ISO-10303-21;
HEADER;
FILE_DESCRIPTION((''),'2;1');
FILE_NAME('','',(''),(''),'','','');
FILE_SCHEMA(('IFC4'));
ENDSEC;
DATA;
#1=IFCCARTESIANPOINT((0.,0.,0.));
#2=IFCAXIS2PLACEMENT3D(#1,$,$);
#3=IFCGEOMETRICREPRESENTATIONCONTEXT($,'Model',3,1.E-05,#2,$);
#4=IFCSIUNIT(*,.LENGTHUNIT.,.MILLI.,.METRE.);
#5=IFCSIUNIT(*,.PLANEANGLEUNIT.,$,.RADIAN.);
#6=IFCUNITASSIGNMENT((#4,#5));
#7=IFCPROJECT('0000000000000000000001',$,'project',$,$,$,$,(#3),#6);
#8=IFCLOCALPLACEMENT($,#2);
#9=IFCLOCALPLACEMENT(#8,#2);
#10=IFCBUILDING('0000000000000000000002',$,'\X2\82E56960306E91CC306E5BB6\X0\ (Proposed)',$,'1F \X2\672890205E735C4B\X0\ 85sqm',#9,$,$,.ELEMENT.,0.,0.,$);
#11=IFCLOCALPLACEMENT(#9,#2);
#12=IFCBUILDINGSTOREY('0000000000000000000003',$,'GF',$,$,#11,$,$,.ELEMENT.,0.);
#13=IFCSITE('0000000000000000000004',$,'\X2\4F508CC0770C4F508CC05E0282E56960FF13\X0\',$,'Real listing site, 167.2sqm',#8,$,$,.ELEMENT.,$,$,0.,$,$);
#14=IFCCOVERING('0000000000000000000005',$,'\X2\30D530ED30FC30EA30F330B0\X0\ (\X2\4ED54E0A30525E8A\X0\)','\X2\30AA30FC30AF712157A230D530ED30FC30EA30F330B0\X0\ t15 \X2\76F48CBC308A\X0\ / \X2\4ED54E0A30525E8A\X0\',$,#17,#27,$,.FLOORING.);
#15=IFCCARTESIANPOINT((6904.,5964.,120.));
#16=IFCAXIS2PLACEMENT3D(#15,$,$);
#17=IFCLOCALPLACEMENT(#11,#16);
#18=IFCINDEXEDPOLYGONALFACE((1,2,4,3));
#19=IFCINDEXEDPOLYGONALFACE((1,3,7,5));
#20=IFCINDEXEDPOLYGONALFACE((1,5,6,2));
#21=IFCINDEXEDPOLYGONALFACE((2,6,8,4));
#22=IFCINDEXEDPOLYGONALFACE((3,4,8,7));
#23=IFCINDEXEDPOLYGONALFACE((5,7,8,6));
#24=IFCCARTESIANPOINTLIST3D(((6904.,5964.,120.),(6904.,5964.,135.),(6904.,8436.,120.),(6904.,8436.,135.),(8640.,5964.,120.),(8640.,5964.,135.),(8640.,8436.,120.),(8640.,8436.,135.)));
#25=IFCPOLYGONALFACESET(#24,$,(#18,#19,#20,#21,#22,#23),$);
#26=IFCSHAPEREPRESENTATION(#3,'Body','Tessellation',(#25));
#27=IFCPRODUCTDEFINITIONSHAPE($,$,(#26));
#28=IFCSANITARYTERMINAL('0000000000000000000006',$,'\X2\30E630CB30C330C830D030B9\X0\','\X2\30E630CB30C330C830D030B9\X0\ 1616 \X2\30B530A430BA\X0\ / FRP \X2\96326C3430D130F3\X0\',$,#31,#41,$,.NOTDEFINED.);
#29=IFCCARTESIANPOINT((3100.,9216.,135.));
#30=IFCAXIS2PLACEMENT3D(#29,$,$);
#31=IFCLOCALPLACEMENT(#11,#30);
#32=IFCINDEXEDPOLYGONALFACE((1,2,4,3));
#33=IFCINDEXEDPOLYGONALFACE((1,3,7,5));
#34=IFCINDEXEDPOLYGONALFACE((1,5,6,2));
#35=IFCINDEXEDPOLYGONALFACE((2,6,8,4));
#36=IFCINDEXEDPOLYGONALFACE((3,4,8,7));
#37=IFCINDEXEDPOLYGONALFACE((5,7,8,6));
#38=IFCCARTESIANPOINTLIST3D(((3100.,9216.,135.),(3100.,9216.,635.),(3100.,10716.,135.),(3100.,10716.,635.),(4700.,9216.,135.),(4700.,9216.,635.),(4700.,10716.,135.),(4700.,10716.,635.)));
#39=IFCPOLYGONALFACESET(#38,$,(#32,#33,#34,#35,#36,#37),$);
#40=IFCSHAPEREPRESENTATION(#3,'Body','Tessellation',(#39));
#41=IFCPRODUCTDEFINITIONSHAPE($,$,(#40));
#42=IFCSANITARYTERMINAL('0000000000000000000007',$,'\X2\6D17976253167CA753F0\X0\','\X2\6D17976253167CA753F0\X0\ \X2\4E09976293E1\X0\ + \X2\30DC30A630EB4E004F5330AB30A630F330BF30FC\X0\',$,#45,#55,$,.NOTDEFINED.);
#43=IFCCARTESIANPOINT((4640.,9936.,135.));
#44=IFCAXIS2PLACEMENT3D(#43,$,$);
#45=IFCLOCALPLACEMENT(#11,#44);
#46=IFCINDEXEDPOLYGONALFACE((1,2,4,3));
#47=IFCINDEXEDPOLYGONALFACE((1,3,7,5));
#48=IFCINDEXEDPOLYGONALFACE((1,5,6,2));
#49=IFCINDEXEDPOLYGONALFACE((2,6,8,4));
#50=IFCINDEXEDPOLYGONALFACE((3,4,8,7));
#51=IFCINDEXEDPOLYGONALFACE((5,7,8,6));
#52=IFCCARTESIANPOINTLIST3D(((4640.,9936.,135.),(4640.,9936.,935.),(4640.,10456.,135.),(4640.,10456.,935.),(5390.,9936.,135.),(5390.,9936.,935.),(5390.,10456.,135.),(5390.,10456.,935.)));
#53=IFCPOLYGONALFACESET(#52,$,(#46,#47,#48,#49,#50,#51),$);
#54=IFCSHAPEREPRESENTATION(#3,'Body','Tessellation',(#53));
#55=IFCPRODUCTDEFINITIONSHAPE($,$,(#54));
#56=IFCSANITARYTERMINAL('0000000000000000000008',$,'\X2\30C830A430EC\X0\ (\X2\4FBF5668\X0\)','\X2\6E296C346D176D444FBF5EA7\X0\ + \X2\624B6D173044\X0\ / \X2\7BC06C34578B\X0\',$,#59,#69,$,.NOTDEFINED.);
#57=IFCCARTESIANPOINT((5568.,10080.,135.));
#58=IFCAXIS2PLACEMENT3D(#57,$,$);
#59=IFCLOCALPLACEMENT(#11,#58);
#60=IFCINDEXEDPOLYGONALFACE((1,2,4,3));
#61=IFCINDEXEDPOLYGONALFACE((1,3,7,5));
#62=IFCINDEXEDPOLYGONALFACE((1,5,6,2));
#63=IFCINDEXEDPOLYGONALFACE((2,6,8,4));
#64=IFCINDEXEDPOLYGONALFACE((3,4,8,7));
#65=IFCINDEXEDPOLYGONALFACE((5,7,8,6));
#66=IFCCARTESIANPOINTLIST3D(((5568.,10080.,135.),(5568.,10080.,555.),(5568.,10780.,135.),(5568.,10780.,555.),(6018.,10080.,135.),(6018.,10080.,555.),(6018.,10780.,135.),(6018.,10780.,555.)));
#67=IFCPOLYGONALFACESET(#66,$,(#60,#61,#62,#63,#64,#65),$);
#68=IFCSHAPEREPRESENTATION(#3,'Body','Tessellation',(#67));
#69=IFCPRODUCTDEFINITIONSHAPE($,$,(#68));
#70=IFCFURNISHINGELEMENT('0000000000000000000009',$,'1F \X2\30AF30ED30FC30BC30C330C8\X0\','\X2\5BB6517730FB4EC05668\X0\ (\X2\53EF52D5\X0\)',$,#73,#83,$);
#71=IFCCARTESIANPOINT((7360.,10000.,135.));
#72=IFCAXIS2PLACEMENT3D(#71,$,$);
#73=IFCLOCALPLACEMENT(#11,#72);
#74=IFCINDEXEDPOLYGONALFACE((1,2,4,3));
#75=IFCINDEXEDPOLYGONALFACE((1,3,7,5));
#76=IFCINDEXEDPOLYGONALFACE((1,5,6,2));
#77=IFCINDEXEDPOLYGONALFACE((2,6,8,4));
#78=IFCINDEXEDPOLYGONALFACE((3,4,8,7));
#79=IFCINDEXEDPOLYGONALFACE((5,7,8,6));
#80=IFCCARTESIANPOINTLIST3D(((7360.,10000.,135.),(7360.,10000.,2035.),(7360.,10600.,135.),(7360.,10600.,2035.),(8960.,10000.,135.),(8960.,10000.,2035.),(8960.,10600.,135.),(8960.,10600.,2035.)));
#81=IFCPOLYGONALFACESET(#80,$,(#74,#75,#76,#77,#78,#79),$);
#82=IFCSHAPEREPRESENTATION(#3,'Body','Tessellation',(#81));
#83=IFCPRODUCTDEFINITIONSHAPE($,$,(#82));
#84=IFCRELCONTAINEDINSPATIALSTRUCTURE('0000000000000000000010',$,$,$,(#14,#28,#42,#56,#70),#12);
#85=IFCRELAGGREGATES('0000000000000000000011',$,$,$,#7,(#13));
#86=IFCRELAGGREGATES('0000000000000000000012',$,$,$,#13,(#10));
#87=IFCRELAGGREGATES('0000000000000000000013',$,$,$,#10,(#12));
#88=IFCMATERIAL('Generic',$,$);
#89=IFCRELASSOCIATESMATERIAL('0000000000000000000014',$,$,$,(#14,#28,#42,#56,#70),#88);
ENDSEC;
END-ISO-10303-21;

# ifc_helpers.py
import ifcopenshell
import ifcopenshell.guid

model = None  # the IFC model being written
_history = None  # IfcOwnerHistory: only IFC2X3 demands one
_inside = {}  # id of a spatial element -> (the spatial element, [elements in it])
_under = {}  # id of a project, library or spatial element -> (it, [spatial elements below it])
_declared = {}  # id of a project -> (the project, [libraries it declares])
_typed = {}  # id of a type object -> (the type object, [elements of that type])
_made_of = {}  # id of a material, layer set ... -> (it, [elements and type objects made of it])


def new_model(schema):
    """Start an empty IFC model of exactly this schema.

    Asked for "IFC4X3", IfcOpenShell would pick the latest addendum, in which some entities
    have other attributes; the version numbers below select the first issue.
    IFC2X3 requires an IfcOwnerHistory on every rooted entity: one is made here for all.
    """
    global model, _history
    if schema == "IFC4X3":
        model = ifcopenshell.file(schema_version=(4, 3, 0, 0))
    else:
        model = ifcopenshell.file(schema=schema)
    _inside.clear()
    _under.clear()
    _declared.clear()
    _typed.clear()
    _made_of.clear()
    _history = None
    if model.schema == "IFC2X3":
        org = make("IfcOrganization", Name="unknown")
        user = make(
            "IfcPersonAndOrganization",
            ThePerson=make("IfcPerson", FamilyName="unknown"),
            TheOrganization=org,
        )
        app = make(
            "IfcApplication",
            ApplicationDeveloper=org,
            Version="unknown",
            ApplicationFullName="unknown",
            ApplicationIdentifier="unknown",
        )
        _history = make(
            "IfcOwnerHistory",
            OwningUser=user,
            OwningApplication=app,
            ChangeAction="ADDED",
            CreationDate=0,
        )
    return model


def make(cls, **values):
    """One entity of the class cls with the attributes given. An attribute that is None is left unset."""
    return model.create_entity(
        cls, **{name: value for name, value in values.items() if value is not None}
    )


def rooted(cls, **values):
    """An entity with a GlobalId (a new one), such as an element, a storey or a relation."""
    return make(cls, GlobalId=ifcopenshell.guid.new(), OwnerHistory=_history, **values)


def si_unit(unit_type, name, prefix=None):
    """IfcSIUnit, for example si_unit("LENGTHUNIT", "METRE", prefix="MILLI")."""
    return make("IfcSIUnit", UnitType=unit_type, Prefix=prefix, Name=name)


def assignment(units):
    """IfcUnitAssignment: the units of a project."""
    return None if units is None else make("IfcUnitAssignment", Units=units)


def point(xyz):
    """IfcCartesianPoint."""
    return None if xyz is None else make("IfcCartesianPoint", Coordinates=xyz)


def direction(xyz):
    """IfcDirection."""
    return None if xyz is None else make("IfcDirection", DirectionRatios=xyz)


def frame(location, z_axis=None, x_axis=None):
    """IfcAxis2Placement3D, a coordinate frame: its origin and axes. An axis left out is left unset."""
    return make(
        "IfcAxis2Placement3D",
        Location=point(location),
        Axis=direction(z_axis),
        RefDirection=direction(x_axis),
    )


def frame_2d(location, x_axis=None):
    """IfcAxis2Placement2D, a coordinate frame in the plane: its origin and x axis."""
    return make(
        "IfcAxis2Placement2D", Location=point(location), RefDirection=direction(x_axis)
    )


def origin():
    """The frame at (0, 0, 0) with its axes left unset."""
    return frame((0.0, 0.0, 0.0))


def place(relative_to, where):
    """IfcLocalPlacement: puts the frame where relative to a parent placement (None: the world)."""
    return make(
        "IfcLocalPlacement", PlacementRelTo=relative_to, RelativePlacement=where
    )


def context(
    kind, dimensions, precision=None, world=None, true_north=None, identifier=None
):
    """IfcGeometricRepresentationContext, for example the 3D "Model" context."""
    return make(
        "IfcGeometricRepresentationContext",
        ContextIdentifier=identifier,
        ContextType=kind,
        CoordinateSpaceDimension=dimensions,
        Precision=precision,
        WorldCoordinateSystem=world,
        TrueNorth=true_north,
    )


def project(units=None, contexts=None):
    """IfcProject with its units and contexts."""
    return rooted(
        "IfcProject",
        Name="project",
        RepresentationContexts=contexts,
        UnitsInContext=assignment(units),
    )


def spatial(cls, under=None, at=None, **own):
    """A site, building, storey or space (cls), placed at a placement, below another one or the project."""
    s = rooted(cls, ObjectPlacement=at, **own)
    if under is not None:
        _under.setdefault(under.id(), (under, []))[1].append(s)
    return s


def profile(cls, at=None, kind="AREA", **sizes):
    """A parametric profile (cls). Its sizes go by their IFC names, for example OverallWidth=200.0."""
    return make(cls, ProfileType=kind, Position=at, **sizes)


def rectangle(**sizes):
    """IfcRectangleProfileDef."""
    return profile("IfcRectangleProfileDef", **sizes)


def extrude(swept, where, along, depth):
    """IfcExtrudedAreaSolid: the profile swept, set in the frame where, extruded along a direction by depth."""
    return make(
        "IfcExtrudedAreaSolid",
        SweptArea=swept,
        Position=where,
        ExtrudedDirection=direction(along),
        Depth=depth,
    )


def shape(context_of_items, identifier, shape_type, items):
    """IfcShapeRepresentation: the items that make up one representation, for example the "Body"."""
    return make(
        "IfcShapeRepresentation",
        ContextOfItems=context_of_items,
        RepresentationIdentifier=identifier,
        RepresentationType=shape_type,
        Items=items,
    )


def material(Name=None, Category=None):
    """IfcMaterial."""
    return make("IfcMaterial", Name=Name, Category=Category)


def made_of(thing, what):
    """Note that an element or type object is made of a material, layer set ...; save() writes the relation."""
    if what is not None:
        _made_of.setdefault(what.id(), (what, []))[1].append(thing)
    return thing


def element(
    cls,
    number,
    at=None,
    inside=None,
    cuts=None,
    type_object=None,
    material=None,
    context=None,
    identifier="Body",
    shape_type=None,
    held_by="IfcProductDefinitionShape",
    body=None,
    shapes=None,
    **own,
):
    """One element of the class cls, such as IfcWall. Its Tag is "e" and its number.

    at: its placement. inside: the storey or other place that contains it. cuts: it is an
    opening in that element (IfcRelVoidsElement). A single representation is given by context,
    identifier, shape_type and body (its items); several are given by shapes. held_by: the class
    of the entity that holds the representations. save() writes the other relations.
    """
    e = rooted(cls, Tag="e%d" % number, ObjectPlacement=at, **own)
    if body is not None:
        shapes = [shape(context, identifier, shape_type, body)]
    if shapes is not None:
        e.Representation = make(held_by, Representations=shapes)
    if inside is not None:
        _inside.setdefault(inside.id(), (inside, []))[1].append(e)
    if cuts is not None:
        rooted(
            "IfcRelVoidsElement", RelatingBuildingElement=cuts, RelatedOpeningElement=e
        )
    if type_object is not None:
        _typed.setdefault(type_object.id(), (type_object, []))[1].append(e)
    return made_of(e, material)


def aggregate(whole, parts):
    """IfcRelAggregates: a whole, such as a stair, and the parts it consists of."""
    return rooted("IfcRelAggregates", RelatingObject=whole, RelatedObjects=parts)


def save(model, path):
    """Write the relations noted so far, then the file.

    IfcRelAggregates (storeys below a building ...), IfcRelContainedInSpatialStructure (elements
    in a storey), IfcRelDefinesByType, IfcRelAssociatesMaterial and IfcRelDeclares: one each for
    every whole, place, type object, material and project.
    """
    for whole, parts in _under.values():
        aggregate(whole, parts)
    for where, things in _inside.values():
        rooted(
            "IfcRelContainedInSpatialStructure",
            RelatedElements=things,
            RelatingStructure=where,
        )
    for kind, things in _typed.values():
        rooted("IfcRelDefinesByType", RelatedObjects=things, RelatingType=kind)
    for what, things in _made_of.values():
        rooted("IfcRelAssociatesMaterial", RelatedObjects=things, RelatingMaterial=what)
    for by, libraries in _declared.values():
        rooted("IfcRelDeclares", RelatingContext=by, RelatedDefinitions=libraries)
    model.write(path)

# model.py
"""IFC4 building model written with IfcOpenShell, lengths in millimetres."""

from ifc_helpers import new_model, si_unit, frame, frame_2d, origin, place, context, project, spatial, rectangle, extrude, material, element, save


model = new_model("IFC4")

# Units and contexts
model_context = context("Model", 3, precision=1e-05, world=origin())
ifc_project = project(units=[si_unit("LENGTHUNIT", "METRE", prefix="MILLI"), si_unit("PLANEANGLEUNIT", "RADIAN")], contexts=[model_context])

# Site, building, storey
site_placement = place(None, origin())
site = spatial("IfcSite", under=ifc_project, at=site_placement, Name="佐賀県佐賀市若楠３", ObjectType="Real listing site, 167.2sqm", CompositionType="ELEMENT", RefElevation=0.0)
building_placement = place(site_placement, origin())
building = spatial("IfcBuilding", under=site, at=building_placement, Name="若楠の里の家 (Proposed)", ObjectType="1F 木造平屋 85sqm", CompositionType="ELEMENT", ElevationOfRefHeight=0.0, ElevationOfTerrain=0.0)
storey_placement = place(building_placement, origin())
storey = spatial("IfcBuildingStorey", under=building, at=storey_placement, Name="GF", CompositionType="ELEMENT", Elevation=0.0)

# Covering
ifc_material_1 = material(Name="Generic")
covering_1_placement = place(storey_placement, frame((6904.0, 5964.0, 120.0)))
element("IfcCovering", 1, at=covering_1_placement, inside=storey, material=ifc_material_1, Name="フローリング (仕上げ床)", Description="オーク無垢フローリング t15 直貼り / 仕上げ床", PredefinedType="FLOORING", context=model_context, shape_type="SweptSolid", body=[
    extrude(rectangle(XDim=1736.0, YDim=2472.0, at=frame_2d((868.0, 1236.0))), frame((6904.0, 5964.0, 120.0)), (0.0, 0.0, 1.0), 15.0),
])

# Sanitary terminals
sanitary_terminal_1_placement = place(storey_placement, frame((3100.0, 9216.0, 135.0)))
element("IfcSanitaryTerminal", 2, at=sanitary_terminal_1_placement, inside=storey, material=ifc_material_1, Name="ユニットバス", Description="ユニットバス 1616 サイズ / FRP 防水パン", PredefinedType="NOTDEFINED", context=model_context, shape_type="SweptSolid", body=[
    extrude(rectangle(XDim=1600.0, YDim=1500.0, at=frame_2d((800.0, 750.0))), frame((3100.0, 9216.0, 135.0)), (0.0, 0.0, 1.0), 500.0),
])
sanitary_terminal_2_placement = place(storey_placement, frame((4640.0, 9936.0, 135.0)))
element("IfcSanitaryTerminal", 3, at=sanitary_terminal_2_placement, inside=storey, material=ifc_material_1, Name="洗面化粧台", Description="洗面化粧台 三面鏡 + ボウル一体カウンター", PredefinedType="NOTDEFINED", context=model_context, shape_type="SweptSolid", body=[
    extrude(rectangle(XDim=750.0, YDim=520.0, at=frame_2d((375.0, 260.0))), frame((4640.0, 9936.0, 135.0)), (0.0, 0.0, 1.0), 800.0),
])
sanitary_terminal_3_placement = place(storey_placement, frame((5568.0, 10080.0, 135.0)))
element("IfcSanitaryTerminal", 4, at=sanitary_terminal_3_placement, inside=storey, material=ifc_material_1, Name="トイレ (便器)", Description="温水洗浄便座 + 手洗い / 節水型", PredefinedType="NOTDEFINED", context=model_context, shape_type="SweptSolid", body=[
    extrude(rectangle(XDim=450.0, YDim=700.0, at=frame_2d((225.0, 350.0))), frame((5568.0, 10080.0, 135.0)), (0.0, 0.0, 1.0), 420.0),
])

# Furnishing element
furnishing_placement = place(storey_placement, frame((7360.0, 10000.0, 135.0)))
element("IfcFurnishingElement", 5, at=furnishing_placement, inside=storey, material=ifc_material_1, Name="1F クローゼット", Description="家具・什器 (可動)", context=model_context, shape_type="SweptSolid", body=[
    extrude(rectangle(XDim=1600.0, YDim=600.0, at=frame_2d((800.0, 300.0))), frame((7360.0, 10000.0, 135.0)), (0.0, 0.0, 1.0), 1900.0),
])

save(model, "model.ifc")
